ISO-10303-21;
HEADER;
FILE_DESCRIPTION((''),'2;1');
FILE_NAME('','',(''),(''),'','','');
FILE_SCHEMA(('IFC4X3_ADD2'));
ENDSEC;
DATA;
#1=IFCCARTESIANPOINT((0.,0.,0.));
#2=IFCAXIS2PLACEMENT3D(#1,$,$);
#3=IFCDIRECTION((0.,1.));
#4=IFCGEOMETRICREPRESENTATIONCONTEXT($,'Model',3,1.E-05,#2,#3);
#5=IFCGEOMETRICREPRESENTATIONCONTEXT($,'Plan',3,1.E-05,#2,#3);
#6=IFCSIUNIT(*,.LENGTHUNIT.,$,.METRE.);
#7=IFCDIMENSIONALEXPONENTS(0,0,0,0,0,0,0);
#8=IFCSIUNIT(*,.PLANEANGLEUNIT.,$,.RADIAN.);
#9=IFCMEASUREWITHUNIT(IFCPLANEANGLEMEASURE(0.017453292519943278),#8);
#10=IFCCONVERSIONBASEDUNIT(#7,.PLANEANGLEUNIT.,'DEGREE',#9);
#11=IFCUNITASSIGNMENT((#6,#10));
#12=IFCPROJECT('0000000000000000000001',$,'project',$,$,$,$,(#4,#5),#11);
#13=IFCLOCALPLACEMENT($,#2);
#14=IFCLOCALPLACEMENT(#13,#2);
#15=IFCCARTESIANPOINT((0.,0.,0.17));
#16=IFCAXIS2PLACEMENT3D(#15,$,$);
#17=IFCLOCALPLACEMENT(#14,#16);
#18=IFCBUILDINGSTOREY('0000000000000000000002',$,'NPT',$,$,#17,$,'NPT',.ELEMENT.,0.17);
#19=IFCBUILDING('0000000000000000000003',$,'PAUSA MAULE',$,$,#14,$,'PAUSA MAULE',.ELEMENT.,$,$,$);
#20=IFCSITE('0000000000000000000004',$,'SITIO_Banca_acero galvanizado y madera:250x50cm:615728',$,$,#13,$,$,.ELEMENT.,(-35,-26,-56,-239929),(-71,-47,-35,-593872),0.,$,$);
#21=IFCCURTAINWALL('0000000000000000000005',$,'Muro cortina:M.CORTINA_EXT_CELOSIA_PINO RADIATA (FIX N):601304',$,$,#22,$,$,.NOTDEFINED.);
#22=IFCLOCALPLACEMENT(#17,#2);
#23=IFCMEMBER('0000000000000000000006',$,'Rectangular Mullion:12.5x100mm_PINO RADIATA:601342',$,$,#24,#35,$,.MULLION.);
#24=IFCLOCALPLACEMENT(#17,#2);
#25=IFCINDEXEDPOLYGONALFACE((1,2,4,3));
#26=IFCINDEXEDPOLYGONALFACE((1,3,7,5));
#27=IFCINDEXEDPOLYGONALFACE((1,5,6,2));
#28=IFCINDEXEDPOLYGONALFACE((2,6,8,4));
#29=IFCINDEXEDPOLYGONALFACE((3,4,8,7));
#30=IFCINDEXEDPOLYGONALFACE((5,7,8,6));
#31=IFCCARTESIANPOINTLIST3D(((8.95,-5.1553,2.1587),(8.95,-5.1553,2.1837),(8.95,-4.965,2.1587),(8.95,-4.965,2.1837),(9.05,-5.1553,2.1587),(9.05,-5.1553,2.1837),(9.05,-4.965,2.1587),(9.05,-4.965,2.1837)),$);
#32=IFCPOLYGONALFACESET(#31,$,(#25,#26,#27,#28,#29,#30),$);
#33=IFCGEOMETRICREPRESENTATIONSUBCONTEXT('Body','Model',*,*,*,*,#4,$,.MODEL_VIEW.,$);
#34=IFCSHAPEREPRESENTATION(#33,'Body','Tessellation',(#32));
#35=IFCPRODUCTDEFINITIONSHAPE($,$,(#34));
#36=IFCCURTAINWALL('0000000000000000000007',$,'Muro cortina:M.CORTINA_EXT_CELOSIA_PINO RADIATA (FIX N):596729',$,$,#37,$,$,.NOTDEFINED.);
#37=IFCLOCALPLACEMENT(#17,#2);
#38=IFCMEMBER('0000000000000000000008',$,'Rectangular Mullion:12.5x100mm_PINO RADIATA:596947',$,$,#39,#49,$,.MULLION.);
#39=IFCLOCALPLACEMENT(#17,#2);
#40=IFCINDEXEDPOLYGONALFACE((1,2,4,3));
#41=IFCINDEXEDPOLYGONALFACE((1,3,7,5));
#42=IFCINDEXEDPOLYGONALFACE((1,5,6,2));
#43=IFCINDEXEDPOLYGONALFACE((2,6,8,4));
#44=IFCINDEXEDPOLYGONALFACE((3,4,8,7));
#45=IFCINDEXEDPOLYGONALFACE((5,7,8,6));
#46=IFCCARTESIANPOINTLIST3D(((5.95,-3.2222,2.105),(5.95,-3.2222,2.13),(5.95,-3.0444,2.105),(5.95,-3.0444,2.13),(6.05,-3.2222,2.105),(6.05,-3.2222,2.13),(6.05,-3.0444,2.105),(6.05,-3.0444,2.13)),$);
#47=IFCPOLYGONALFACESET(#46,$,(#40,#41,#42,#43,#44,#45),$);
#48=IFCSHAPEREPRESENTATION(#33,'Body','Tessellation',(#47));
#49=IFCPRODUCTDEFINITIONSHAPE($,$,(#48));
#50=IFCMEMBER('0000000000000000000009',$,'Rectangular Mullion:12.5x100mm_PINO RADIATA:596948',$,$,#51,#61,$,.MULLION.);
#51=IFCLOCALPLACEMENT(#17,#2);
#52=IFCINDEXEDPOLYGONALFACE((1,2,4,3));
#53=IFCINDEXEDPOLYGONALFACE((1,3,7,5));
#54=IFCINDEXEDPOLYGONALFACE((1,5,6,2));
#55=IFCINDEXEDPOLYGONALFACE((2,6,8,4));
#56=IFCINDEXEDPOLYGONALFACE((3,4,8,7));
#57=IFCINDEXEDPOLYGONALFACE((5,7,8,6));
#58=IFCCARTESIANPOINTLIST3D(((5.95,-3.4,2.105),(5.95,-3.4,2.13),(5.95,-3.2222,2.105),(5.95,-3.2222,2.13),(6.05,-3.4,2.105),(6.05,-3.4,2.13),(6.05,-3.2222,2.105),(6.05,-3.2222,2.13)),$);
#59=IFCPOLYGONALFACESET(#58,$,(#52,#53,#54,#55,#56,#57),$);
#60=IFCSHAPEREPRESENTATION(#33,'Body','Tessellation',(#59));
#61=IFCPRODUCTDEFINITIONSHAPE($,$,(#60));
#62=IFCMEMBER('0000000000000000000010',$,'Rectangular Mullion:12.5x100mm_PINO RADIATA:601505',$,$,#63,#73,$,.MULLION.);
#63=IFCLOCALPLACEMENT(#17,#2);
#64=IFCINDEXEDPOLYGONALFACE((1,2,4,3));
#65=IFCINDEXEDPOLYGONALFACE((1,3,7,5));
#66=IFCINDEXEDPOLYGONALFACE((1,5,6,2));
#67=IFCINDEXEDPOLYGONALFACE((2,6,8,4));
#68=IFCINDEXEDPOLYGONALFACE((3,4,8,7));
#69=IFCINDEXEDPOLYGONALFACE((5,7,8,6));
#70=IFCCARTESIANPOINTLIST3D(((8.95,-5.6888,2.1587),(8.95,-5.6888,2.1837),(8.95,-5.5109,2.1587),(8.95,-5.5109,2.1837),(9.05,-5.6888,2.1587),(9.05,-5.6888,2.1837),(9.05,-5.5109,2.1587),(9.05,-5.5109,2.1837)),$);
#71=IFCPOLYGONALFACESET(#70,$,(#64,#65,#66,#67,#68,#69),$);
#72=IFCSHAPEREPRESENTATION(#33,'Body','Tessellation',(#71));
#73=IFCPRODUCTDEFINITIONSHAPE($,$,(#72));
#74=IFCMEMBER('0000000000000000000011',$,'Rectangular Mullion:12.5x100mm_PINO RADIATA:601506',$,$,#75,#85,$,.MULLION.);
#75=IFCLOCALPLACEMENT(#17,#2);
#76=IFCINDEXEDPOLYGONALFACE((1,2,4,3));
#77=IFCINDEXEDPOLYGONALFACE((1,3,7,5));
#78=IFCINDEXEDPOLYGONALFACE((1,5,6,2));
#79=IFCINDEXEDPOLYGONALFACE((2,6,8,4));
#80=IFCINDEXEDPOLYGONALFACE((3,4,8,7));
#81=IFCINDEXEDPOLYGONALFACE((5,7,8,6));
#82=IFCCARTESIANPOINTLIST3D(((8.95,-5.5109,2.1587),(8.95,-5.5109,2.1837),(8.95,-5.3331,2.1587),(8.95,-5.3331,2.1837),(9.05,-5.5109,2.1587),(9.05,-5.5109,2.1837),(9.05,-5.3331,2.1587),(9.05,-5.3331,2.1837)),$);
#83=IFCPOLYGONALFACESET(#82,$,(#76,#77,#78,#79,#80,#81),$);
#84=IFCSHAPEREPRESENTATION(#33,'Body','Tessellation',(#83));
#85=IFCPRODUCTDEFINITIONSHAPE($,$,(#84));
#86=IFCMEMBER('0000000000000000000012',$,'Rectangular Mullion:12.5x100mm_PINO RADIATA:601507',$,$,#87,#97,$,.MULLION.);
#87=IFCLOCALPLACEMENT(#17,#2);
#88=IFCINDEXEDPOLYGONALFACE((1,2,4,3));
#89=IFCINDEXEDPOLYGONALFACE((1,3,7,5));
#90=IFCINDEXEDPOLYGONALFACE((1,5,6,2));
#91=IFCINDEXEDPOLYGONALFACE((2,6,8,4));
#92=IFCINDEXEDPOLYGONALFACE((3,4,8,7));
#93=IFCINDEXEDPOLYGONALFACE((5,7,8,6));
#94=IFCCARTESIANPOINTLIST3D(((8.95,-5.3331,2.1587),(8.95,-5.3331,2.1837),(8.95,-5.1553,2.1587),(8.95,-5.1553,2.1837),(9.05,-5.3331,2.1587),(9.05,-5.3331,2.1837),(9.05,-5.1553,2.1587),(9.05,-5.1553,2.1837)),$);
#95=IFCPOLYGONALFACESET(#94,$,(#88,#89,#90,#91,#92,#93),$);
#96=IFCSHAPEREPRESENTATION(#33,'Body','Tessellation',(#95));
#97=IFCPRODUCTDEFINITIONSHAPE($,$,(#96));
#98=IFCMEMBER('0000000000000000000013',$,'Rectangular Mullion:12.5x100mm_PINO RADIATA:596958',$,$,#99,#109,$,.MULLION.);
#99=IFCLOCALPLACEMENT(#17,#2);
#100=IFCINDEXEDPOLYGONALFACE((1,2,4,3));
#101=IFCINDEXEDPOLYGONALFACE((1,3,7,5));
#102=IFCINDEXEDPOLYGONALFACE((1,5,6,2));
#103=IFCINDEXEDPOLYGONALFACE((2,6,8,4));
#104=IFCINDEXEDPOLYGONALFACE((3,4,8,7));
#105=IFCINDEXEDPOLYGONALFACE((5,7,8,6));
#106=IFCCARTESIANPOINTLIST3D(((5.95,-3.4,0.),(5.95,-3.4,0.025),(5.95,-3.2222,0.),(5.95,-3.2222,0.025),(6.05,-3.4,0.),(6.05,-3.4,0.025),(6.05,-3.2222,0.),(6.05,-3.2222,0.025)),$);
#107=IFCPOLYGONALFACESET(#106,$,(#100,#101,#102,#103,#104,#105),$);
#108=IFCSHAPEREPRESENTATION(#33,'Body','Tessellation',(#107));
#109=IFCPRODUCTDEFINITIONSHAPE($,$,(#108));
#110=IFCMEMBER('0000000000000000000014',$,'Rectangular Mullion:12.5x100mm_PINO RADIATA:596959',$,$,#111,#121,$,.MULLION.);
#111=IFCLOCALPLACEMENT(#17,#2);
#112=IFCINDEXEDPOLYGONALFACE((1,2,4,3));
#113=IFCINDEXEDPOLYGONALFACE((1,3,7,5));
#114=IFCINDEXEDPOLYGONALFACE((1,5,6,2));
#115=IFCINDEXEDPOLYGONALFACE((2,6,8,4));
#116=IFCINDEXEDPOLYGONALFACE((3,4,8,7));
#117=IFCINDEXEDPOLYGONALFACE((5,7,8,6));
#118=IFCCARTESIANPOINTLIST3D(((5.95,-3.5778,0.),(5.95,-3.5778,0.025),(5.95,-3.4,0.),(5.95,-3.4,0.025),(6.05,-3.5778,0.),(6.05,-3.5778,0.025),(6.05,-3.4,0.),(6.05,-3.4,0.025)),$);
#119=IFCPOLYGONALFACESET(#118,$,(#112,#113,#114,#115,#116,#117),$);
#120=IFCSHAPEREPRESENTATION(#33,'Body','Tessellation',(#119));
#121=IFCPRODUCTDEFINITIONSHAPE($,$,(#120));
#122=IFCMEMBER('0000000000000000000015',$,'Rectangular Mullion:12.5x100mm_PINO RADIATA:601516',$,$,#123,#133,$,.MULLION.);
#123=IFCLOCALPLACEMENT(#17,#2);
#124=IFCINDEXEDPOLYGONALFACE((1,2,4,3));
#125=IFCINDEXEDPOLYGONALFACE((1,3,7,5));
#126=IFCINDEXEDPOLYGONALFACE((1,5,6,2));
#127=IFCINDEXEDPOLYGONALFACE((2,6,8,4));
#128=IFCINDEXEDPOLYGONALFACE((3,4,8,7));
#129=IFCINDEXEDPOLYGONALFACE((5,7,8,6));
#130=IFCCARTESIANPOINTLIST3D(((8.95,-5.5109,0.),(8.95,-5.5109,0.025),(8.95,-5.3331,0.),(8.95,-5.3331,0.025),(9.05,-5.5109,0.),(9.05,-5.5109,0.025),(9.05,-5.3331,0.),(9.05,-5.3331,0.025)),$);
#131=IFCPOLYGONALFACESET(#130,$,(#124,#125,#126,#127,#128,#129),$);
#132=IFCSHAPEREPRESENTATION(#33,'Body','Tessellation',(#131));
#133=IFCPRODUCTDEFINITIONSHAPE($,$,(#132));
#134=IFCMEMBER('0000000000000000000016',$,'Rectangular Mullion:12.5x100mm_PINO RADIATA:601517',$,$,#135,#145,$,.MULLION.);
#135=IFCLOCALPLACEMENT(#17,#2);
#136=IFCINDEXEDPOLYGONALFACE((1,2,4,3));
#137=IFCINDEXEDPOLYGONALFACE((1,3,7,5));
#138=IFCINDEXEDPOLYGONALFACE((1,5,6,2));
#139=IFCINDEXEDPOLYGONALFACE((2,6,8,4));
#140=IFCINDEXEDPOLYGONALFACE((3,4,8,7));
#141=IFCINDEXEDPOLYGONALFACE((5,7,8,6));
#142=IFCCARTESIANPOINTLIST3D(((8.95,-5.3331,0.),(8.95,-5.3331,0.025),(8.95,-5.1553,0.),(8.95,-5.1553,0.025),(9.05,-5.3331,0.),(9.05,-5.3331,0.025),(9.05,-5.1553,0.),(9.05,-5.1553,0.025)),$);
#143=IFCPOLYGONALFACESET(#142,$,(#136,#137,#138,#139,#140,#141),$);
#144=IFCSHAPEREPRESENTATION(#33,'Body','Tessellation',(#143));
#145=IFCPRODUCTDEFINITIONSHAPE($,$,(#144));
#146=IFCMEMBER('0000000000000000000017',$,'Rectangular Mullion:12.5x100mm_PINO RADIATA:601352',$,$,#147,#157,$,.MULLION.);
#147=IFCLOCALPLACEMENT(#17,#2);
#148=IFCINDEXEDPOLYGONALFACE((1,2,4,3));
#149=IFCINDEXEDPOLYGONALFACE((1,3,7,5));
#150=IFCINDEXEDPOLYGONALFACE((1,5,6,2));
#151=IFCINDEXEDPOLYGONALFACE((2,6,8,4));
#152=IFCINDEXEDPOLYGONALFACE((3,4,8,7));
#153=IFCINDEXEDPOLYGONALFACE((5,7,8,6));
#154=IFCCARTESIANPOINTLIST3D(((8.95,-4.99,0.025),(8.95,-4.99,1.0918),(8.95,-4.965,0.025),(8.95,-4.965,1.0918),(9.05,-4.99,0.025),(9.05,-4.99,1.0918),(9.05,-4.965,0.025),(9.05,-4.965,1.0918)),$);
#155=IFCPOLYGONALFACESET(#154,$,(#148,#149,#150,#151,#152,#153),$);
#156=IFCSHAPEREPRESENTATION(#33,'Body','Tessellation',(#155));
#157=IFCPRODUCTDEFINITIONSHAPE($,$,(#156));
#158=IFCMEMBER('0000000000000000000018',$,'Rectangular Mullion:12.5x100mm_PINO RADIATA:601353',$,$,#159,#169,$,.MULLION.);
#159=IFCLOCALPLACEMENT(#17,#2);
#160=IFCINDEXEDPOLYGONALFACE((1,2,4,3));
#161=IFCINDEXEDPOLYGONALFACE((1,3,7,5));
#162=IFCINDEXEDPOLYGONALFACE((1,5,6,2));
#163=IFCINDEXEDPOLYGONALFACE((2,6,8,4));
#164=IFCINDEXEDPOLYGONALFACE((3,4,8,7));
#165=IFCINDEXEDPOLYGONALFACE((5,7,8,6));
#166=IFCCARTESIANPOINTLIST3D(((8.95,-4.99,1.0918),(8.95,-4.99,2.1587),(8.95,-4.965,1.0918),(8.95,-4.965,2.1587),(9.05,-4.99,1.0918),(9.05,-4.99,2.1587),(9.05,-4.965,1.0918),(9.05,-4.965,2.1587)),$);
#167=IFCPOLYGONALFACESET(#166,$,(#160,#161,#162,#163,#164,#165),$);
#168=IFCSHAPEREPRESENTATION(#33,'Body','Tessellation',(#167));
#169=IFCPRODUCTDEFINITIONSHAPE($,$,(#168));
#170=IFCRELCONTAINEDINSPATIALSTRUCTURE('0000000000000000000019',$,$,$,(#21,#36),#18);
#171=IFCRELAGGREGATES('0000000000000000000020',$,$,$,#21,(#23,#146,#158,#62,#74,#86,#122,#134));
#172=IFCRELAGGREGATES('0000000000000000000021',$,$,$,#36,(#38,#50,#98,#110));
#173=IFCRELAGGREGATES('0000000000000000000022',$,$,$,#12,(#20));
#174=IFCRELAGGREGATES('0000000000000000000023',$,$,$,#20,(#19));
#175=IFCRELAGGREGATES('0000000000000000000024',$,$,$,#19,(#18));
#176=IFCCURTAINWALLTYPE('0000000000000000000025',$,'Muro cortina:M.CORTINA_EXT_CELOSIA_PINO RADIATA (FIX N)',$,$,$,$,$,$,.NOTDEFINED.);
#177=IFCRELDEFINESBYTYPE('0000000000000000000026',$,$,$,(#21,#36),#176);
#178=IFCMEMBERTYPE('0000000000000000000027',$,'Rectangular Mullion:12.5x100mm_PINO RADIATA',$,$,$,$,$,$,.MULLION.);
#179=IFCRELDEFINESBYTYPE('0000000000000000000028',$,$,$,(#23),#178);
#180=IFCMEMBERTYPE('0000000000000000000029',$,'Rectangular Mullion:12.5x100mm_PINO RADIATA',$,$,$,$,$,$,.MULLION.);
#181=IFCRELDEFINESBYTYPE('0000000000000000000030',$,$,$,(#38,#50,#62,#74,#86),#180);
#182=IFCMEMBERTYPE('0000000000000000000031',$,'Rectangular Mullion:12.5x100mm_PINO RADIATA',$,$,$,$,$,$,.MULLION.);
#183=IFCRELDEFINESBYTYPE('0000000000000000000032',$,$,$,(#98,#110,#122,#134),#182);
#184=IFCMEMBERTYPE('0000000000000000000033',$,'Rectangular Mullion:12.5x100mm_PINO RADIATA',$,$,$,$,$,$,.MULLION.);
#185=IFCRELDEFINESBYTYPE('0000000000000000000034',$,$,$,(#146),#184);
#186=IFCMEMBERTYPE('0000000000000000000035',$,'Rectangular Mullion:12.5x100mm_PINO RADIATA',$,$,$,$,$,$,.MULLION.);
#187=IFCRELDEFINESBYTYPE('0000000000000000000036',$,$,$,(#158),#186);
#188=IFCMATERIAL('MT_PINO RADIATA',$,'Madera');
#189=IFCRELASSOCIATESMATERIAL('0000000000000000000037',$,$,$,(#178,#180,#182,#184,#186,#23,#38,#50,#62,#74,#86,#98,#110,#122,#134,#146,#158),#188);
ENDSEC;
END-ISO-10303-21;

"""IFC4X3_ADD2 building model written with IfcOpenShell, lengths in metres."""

from ifc_helpers import new_model, entity, si_unit, converted_unit, direction, frame, frame_2d, origin, origin_2d_with_axis, place, context, subcontext, project, spatial, rectangle, extrude, source, transform, mapped, material, material_profile, profile_set, profile_usage, type_object, type_shapes, element, aggregate, save


model = new_model("IFC4X3_ADD2")

# Units and contexts
model_context = context("Model", 3, precision=1e-05, world=origin(), true_north=direction((0.0, 1.0)))
plan_context = context("Plan", 3, precision=1e-05, world=origin(), true_north=direction((0.0, 1.0)))
body_context = subcontext(model_context, "Body", "Model", "MODEL_VIEW")
ifc_project = project(units=[si_unit("LENGTHUNIT", "METRE"), converted_unit("PLANEANGLEUNIT", "DEGREE", entity("IfcPlaneAngleMeasure", 0.017453292519943278), si_unit("PLANEANGLEUNIT", "RADIAN"), dimensions=[0, 0, 0, 0, 0, 0, 0])], contexts=[model_context, plan_context])

# Site, building, storey
site_placement = place(None, origin())
site = spatial("IfcSite", under=ifc_project, at=site_placement, Name="SITIO_Banca_acero galvanizado y madera:250x50cm:615728", CompositionType="ELEMENT", RefLatitude=(-35, -26, -56, -239929), RefLongitude=(-71, -47, -35, -593872), RefElevation=0.0)
building_placement = place(site_placement, origin())
building = spatial("IfcBuilding", under=site, at=building_placement, Name="PAUSA MAULE", LongName="PAUSA MAULE", CompositionType="ELEMENT")
storey_placement = place(building_placement, frame((0.0, 0.0, 0.17)))
storey = spatial("IfcBuildingStorey", under=building, at=storey_placement, Name="NPT", LongName="NPT", CompositionType="ELEMENT", Elevation=0.17)

# Curtain wall, member
curtain_wall_type = type_object("IfcCurtainWallType", Name="Muro cortina:M.CORTINA_EXT_CELOSIA_PINO RADIATA (FIX N)", PredefinedType="NOTDEFINED")
curtain_wall_1_placement = place(storey_placement, frame((0.0, 0.0, -0.17)))
curtain_wall_1 = element("IfcCurtainWall", 1, at=curtain_wall_1_placement, inside=storey, type_object=curtain_wall_type, Name="Muro cortina:M.CORTINA_EXT_CELOSIA_PINO RADIATA (FIX N):601304", PredefinedType="NOTDEFINED")
ifc_material = material(Name="MT_PINO RADIATA", Category="Madera")
ifc_material_profile = material_profile(ifc_material, rectangle(XDim=0.025, YDim=0.1, at=frame_2d((0.0, 0.0), x_axis=(1.0, 0.0))), Name="12.5x100mm_PINO RADIATA")
ifc_profile_set = profile_set([ifc_material_profile], Name="12.5x100mm_PINO RADIATA")
ifc_profile_usage = profile_usage(ifc_profile_set)
member_type_1 = type_object("IfcMemberType", Name="Rectangular Mullion:12.5x100mm_PINO RADIATA", PredefinedType="MULLION", material=ifc_profile_set)
shared_shape_1 = source(origin(), body_context, "Body", "SweptSolid", [
    extrude(rectangle(XDim=0.025, YDim=0.1, at=frame_2d((0.0, 0.0), x_axis=(1.0, 0.0))), frame((-0.0125, 0.0, -0.1903), z_axis=(0.0, 0.0, 1.0), x_axis=(-1.0, 0.0, 0.0)), (0.0, 0.0, 1.0), 0.1903),
])
type_shapes(member_type_1, [shared_shape_1])
member_1_placement = place(curtain_wall_1_placement, frame((9.0, -4.965, 2.3537), z_axis=(0.0, 1.0, 0.0), x_axis=(0.0, 0.0, 1.0)))
member_1 = element("IfcMember", 2, at=member_1_placement, type_object=member_type_1, material=ifc_profile_usage, Name="Rectangular Mullion:12.5x100mm_PINO RADIATA:601342", PredefinedType="MULLION", context=body_context, shape_type="MappedRepresentation", body=[
    mapped(shared_shape_1, transform((0.0, 0.0, 0.0), scale=1.0)),
])

# Curtain wall, members
curtain_wall_2_placement = place(storey_placement, frame((0.0, 0.0, -0.17)))
curtain_wall_2 = element("IfcCurtainWall", 3, at=curtain_wall_2_placement, inside=storey, type_object=curtain_wall_type, Name="Muro cortina:M.CORTINA_EXT_CELOSIA_PINO RADIATA (FIX N):596729", PredefinedType="NOTDEFINED")
member_type_2 = type_object("IfcMemberType", Name="Rectangular Mullion:12.5x100mm_PINO RADIATA", PredefinedType="MULLION", material=ifc_profile_set)
shared_shape_2 = source(origin(), body_context, "Body", "SweptSolid", [
    extrude(rectangle(XDim=0.025, YDim=0.1, at=frame_2d((0.0, 0.0), x_axis=(1.0, 0.0))), frame((-0.0125, 0.0, -0.1778), z_axis=(0.0, 0.0, 1.0), x_axis=(-1.0, 0.0, 0.0)), (0.0, 0.0, 1.0), 0.1778),
])
type_shapes(member_type_2, [shared_shape_2])
member_2_placement = place(curtain_wall_2_placement, frame((6.0, -3.2222, 2.3), z_axis=(0.0, -1.0, 0.0), x_axis=(0.0, 0.0, 1.0)))
member_2 = element("IfcMember", 4, at=member_2_placement, type_object=member_type_2, material=ifc_profile_usage, Name="Rectangular Mullion:12.5x100mm_PINO RADIATA:596947", PredefinedType="MULLION", context=body_context, shape_type="MappedRepresentation", body=[
    mapped(shared_shape_2, transform((0.0, 0.0, 0.0), scale=1.0)),
])
member_3_placement = place(curtain_wall_2_placement, frame((6.0, -3.4, 2.3), z_axis=(0.0, -1.0, 0.0), x_axis=(0.0, 0.0, 1.0)))
member_3 = element("IfcMember", 5, at=member_3_placement, type_object=member_type_2, material=ifc_profile_usage, Name="Rectangular Mullion:12.5x100mm_PINO RADIATA:596948", PredefinedType="MULLION", context=body_context, shape_type="MappedRepresentation", body=[
    mapped(shared_shape_2, transform((0.0, 0.0, 0.0), scale=1.0)),
])

# Members
member_4_placement = place(curtain_wall_1_placement, frame((9.0, -5.5109, 2.3537), z_axis=(0.0, 1.0, 0.0), x_axis=(0.0, 0.0, 1.0)))
member_4 = element("IfcMember", 6, at=member_4_placement, type_object=member_type_2, material=ifc_profile_usage, Name="Rectangular Mullion:12.5x100mm_PINO RADIATA:601505", PredefinedType="MULLION", context=body_context, shape_type="MappedRepresentation", body=[
    mapped(shared_shape_2, transform((0.0, 0.0, 0.0), scale=1.0)),
])
member_5_placement = place(curtain_wall_1_placement, frame((9.0, -5.3331, 2.3537), z_axis=(0.0, 1.0, 0.0), x_axis=(0.0, 0.0, 1.0)))
member_5 = element("IfcMember", 7, at=member_5_placement, type_object=member_type_2, material=ifc_profile_usage, Name="Rectangular Mullion:12.5x100mm_PINO RADIATA:601506", PredefinedType="MULLION", context=body_context, shape_type="MappedRepresentation", body=[
    mapped(shared_shape_2, transform((0.0, 0.0, 0.0), scale=1.0)),
])
member_6_placement = place(curtain_wall_1_placement, frame((9.0, -5.1553, 2.3537), z_axis=(0.0, 1.0, 0.0), x_axis=(0.0, 0.0, 1.0)))
member_6 = element("IfcMember", 8, at=member_6_placement, type_object=member_type_2, material=ifc_profile_usage, Name="Rectangular Mullion:12.5x100mm_PINO RADIATA:601507", PredefinedType="MULLION", context=body_context, shape_type="MappedRepresentation", body=[
    mapped(shared_shape_2, transform((0.0, 0.0, 0.0), scale=1.0)),
])
member_type_3 = type_object("IfcMemberType", Name="Rectangular Mullion:12.5x100mm_PINO RADIATA", PredefinedType="MULLION", material=ifc_profile_set)
shared_shape_3 = source(origin(), body_context, "Body", "SweptSolid", [
    extrude(rectangle(XDim=0.025, YDim=0.1, at=frame_2d((0.0, 0.0), x_axis=(1.0, 0.0))), frame((-0.0125, 0.0, -0.1778), z_axis=(0.0, 0.0, 1.0), x_axis=(-1.0, 0.0, 0.0)), (0.0, 0.0, 1.0), 0.1778),
])
type_shapes(member_type_3, [shared_shape_3])
member_7_placement = place(curtain_wall_2_placement, frame((6.0, -3.2222, 0.17), z_axis=(0.0, 1.0, 0.0), x_axis=(0.0, 0.0, -1.0)))
member_7 = element("IfcMember", 9, at=member_7_placement, type_object=member_type_3, material=ifc_profile_usage, Name="Rectangular Mullion:12.5x100mm_PINO RADIATA:596958", PredefinedType="MULLION", context=body_context, shape_type="MappedRepresentation", body=[
    mapped(shared_shape_3, transform((0.0, 0.0, 0.0), scale=1.0)),
])
member_8_placement = place(curtain_wall_2_placement, frame((6.0, -3.4, 0.17), z_axis=(0.0, 1.0, 0.0), x_axis=(0.0, 0.0, -1.0)))
member_8 = element("IfcMember", 10, at=member_8_placement, type_object=member_type_3, material=ifc_profile_usage, Name="Rectangular Mullion:12.5x100mm_PINO RADIATA:596959", PredefinedType="MULLION", context=body_context, shape_type="MappedRepresentation", body=[
    mapped(shared_shape_3, transform((0.0, 0.0, 0.0), scale=1.0)),
])
member_9_placement = place(curtain_wall_1_placement, frame((9.0, -5.5109, 0.17), z_axis=(0.0, -1.0, 0.0), x_axis=(0.0, 0.0, -1.0)))
member_9 = element("IfcMember", 11, at=member_9_placement, type_object=member_type_3, material=ifc_profile_usage, Name="Rectangular Mullion:12.5x100mm_PINO RADIATA:601516", PredefinedType="MULLION", context=body_context, shape_type="MappedRepresentation", body=[
    mapped(shared_shape_3, transform((0.0, 0.0, 0.0), scale=1.0)),
])
member_10_placement = place(curtain_wall_1_placement, frame((9.0, -5.3331, 0.17), z_axis=(0.0, -1.0, 0.0), x_axis=(0.0, 0.0, -1.0)))
member_10 = element("IfcMember", 12, at=member_10_placement, type_object=member_type_3, material=ifc_profile_usage, Name="Rectangular Mullion:12.5x100mm_PINO RADIATA:601517", PredefinedType="MULLION", context=body_context, shape_type="MappedRepresentation", body=[
    mapped(shared_shape_3, transform((0.0, 0.0, 0.0), scale=1.0)),
])
member_type_4 = type_object("IfcMemberType", Name="Rectangular Mullion:12.5x100mm_PINO RADIATA", PredefinedType="MULLION", material=ifc_profile_set)
shared_shape_4 = source(origin(), body_context, "Body", "SweptSolid", [
    extrude(rectangle(XDim=0.025, YDim=0.1, at=origin_2d_with_axis()), frame((-0.0125, 0.0, -1.0668), z_axis=(0.0, 0.0, 1.0), x_axis=(-1.0, 0.0, 0.0)), (0.0, 0.0, 1.0), 1.0668),
])
type_shapes(member_type_4, [shared_shape_4])
member_11_placement = place(curtain_wall_1_placement, frame((9.0, -4.965, 0.195), z_axis=(0.0, 0.0, -1.0), x_axis=(0.0, 1.0, 0.0)))
member_11 = element("IfcMember", 13, at=member_11_placement, type_object=member_type_4, material=ifc_profile_usage, Name="Rectangular Mullion:12.5x100mm_PINO RADIATA:601352", PredefinedType="MULLION", context=body_context, shape_type="MappedRepresentation", body=[
    mapped(shared_shape_4, transform((0.0, 0.0, 0.0), scale=1.0)),
])
member_type_5 = type_object("IfcMemberType", Name="Rectangular Mullion:12.5x100mm_PINO RADIATA", PredefinedType="MULLION", material=ifc_profile_set)
shared_shape_5 = source(origin(), body_context, "Body", "SweptSolid", [
    extrude(rectangle(XDim=0.025, YDim=0.1, at=frame_2d((0.0, 0.0), x_axis=(1.0, 0.0))), frame((-0.0125, 0.0, -1.0668), z_axis=(0.0, 0.0, 1.0), x_axis=(-1.0, 0.0, 0.0)), (0.0, 0.0, 1.0), 1.0668),
])
type_shapes(member_type_5, [shared_shape_5])
member_12_placement = place(curtain_wall_1_placement, frame((9.0, -4.965, 1.2618), z_axis=(0.0, 0.0, -1.0), x_axis=(0.0, 1.0, 0.0)))
member_12 = element("IfcMember", 14, at=member_12_placement, type_object=member_type_5, material=ifc_profile_usage, Name="Rectangular Mullion:12.5x100mm_PINO RADIATA:601353", PredefinedType="MULLION", context=body_context, shape_type="MappedRepresentation", body=[
    mapped(shared_shape_5, transform((0.0, 0.0, 0.0), scale=1.0)),
])
aggregate(curtain_wall_1, [member_1, member_11, member_12, member_4, member_5, member_6, member_9, member_10])
aggregate(curtain_wall_2, [member_2, member_3, member_7, member_8])

save(model, "model.ifc")
